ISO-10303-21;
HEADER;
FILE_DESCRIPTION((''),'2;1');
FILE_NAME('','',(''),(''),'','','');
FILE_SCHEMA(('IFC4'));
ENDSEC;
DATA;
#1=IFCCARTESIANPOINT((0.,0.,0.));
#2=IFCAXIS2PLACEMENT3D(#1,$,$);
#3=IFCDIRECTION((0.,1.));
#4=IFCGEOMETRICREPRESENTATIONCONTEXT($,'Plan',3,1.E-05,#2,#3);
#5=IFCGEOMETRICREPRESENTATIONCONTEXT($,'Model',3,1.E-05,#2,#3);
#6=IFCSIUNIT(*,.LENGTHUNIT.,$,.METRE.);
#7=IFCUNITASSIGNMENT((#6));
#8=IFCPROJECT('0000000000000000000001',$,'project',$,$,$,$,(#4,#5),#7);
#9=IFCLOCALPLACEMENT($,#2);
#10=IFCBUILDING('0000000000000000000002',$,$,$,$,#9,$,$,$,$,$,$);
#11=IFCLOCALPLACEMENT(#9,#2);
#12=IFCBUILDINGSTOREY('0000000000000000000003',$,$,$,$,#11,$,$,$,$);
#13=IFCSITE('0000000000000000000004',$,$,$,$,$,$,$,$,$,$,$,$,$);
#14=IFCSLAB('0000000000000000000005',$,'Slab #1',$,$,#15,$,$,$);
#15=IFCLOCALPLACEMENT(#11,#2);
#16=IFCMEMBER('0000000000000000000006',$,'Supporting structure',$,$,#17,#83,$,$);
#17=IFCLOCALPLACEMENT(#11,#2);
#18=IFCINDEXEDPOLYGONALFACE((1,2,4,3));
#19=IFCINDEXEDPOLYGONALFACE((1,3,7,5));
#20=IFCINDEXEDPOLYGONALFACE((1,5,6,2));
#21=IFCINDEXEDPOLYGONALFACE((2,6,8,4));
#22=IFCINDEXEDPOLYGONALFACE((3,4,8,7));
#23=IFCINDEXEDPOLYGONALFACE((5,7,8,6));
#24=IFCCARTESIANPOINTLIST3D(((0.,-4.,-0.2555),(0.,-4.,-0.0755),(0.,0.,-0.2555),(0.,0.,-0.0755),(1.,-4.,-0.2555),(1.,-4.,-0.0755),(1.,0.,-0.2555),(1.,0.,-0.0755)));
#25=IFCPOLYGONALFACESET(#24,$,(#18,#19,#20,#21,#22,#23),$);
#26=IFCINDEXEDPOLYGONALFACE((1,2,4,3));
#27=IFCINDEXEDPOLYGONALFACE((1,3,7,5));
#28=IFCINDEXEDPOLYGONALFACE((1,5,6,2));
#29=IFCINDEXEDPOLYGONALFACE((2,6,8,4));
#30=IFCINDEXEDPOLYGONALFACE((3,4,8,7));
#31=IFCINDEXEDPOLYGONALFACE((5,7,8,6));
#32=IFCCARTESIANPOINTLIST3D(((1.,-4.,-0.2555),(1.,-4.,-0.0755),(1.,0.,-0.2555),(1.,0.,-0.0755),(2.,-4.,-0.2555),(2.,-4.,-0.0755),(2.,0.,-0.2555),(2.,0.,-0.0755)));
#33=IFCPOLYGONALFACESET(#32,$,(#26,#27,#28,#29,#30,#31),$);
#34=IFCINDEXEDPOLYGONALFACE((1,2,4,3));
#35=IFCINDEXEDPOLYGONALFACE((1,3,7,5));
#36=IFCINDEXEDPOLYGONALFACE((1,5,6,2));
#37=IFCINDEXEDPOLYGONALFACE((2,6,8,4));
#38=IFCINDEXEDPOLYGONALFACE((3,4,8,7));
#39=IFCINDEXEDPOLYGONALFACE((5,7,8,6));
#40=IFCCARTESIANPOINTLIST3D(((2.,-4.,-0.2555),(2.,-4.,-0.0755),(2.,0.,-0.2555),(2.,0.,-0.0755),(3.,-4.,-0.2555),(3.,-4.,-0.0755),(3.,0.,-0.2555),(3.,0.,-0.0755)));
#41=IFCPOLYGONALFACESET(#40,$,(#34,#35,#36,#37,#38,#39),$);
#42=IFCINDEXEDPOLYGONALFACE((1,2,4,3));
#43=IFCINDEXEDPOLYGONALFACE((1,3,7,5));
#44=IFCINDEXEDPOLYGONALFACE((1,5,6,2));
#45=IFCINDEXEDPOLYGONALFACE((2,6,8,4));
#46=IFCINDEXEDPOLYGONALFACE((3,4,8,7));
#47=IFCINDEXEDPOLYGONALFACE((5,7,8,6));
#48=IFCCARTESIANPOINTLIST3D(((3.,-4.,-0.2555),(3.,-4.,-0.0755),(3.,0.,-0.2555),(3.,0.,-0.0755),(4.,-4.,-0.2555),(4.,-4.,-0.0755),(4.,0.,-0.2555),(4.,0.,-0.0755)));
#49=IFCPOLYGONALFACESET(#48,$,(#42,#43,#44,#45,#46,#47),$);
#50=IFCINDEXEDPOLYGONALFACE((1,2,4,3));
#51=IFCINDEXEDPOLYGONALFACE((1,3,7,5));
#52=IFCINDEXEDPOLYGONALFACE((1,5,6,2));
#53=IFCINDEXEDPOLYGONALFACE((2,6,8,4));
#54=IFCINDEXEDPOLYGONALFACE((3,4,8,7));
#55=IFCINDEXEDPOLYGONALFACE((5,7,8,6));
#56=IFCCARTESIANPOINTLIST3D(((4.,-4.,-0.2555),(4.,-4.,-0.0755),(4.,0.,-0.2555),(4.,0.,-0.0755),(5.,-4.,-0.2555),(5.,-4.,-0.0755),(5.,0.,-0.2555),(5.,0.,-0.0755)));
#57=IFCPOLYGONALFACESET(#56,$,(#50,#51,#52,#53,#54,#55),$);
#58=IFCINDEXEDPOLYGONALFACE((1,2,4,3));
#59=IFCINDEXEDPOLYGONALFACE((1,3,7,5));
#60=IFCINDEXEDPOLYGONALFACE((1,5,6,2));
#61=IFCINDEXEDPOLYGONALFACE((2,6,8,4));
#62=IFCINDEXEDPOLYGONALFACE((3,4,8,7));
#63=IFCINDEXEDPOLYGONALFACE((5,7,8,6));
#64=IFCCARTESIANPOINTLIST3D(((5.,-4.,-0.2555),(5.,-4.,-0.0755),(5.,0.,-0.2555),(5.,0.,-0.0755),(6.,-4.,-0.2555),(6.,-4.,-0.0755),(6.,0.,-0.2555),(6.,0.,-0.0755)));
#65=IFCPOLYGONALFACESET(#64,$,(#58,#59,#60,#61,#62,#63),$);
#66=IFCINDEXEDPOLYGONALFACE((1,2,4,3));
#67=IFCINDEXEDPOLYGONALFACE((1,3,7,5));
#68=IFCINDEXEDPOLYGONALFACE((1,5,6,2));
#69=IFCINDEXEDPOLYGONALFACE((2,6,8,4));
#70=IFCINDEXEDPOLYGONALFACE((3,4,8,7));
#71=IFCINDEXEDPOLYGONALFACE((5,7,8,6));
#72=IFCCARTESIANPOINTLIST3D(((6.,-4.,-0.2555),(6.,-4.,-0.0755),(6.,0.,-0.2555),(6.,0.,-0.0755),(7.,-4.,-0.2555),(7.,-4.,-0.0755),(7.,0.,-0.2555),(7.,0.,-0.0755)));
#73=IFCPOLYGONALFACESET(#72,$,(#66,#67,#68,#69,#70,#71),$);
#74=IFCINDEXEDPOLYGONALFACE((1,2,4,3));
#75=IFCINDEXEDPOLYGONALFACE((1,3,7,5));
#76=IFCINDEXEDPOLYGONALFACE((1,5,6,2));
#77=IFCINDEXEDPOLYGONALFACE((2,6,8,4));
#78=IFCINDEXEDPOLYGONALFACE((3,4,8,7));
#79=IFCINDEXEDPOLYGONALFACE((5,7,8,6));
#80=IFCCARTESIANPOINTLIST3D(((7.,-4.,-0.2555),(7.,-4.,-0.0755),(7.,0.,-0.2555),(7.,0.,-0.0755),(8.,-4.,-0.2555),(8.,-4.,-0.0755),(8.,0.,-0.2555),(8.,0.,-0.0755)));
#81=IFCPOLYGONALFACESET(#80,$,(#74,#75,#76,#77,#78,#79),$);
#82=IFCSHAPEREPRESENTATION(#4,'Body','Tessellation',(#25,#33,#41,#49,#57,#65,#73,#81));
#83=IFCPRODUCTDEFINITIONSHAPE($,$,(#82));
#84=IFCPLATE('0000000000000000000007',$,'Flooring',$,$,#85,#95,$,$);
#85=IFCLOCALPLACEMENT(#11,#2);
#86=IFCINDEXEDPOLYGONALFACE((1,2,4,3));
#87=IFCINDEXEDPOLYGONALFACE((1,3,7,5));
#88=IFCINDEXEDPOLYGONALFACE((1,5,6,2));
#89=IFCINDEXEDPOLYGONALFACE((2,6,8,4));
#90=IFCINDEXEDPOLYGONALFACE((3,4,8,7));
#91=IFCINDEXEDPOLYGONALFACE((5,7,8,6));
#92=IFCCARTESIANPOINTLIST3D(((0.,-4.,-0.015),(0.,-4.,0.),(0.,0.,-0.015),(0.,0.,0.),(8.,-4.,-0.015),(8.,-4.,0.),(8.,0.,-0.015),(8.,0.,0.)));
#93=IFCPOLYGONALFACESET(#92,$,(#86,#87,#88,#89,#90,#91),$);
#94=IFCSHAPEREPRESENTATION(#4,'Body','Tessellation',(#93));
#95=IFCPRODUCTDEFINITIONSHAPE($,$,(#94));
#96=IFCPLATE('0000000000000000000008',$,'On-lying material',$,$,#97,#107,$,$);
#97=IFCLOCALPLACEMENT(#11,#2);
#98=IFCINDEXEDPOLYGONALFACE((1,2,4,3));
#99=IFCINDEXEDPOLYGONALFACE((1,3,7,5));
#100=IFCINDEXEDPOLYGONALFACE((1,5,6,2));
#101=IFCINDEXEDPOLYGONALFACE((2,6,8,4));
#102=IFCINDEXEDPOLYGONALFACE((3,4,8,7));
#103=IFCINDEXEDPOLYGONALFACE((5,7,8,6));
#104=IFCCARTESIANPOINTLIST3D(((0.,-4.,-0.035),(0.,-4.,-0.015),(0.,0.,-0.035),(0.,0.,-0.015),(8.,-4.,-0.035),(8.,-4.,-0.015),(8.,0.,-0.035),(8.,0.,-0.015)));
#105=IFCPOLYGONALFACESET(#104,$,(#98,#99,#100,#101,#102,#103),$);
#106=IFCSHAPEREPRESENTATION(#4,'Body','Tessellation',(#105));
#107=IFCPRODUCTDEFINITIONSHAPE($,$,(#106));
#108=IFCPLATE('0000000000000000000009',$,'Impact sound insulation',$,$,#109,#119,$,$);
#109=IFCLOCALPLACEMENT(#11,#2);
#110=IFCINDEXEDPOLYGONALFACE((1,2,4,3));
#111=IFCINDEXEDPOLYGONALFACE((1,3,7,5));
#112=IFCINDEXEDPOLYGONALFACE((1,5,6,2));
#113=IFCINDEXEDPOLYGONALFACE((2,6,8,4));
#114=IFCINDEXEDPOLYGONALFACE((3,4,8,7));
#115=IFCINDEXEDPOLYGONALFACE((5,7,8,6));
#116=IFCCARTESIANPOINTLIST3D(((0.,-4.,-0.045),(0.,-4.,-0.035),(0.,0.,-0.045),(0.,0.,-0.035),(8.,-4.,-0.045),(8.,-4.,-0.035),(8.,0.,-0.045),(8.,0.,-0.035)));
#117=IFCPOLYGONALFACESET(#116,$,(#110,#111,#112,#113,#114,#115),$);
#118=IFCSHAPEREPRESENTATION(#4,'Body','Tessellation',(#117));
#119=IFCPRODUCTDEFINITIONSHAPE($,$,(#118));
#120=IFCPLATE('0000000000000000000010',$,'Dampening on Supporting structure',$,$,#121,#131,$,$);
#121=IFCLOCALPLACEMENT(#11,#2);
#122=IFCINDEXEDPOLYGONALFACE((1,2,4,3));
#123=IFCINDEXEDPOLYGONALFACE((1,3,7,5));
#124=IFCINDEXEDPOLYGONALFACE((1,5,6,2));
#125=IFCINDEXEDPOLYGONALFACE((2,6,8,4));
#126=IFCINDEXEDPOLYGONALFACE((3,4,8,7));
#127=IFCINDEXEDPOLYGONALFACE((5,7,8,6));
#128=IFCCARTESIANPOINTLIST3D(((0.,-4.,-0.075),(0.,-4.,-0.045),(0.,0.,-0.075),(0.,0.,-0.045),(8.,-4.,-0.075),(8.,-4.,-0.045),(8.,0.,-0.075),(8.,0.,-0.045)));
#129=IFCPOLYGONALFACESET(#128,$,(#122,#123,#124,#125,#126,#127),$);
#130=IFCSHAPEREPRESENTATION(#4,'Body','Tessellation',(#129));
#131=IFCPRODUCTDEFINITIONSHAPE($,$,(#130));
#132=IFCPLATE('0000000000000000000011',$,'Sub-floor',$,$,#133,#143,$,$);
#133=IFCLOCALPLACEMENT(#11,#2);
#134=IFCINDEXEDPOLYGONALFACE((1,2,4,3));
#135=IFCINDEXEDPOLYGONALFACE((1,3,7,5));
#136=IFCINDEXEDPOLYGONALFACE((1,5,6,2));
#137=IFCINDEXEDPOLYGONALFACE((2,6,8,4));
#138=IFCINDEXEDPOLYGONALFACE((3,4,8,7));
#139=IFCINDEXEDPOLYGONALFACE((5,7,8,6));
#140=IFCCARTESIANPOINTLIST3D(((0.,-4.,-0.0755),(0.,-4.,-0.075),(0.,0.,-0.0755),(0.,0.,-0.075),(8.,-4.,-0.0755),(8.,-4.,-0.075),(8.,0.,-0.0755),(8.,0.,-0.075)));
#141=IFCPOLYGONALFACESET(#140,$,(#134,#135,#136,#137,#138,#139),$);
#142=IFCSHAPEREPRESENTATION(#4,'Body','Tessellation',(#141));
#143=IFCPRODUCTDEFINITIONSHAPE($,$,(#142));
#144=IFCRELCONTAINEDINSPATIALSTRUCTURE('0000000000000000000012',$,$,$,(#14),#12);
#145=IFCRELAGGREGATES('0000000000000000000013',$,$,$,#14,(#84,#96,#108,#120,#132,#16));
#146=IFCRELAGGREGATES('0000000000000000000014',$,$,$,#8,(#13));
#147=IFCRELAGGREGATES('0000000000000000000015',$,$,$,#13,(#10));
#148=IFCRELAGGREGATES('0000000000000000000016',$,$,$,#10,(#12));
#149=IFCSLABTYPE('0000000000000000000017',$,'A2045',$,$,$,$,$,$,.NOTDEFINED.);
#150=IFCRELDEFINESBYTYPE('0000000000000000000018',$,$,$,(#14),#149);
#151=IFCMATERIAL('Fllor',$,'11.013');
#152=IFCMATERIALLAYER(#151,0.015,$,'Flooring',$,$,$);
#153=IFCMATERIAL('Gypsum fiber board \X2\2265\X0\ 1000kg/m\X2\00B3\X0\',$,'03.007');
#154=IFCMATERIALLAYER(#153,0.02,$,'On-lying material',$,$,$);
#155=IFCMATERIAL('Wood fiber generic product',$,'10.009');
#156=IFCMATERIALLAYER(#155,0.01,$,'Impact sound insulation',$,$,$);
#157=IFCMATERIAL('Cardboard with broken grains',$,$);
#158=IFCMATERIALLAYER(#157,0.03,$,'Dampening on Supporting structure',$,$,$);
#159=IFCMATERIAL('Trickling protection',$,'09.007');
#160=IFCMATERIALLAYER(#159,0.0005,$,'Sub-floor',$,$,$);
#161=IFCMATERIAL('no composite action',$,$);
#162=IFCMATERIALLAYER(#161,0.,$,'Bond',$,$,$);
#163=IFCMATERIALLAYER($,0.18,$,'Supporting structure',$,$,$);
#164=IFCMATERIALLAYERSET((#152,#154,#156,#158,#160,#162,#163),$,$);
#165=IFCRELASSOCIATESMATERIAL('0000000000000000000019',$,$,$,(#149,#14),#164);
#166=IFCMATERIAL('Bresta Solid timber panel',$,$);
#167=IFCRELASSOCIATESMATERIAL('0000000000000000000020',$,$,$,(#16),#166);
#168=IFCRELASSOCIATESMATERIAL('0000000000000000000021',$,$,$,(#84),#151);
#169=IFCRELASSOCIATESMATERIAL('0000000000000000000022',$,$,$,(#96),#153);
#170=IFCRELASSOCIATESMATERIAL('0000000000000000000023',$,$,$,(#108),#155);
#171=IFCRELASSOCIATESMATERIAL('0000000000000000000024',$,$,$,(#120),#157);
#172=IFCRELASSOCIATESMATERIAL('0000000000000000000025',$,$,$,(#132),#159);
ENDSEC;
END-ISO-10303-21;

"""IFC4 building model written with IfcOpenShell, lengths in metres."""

from ifc_helpers import new_model, si_unit, direction, frame, frame_2d, origin, origin_with_axes, place, context, project, spatial, rectangle, extrude, material, layer, layer_set, type_object, element, aggregate, save


model = new_model("IFC4")

# Units and contexts
plan_context = context("Plan", 3, precision=1e-05, world=origin(), true_north=direction((0.0, 1.0)))
model_context = context("Model", 3, precision=1e-05, world=origin(), true_north=direction((0.0, 1.0)))
ifc_project = project(units=[si_unit("LENGTHUNIT", "METRE")], contexts=[plan_context, model_context])

# Site, building, storey
site = spatial("IfcSite", under=ifc_project)
building_placement = place(None, origin())
building = spatial("IfcBuilding", under=site, at=building_placement)
storey_placement = place(building_placement, origin())
storey = spatial("IfcBuildingStorey", under=building, at=storey_placement)

# Slab, member, plates
ifc_material_1 = material(Name="Fllor", Category="11.013")
ifc_layer_1 = layer(ifc_material_1, 0.015, Name="Flooring")
ifc_material_2 = material(Name="Gypsum fiber board ≥ 1000kg/m³", Category="03.007")
ifc_layer_2 = layer(ifc_material_2, 0.02, Name="On-lying material")
ifc_material_3 = material(Name="Wood fiber generic product", Category="10.009")
ifc_layer_3 = layer(ifc_material_3, 0.01, Name="Impact sound insulation")
ifc_material_4 = material(Name="Cardboard with broken grains")
ifc_layer_4 = layer(ifc_material_4, 0.03, Name="Dampening on Supporting structure")
ifc_material_5 = material(Name="Trickling protection", Category="09.007")
ifc_layer_5 = layer(ifc_material_5, 0.0005, Name="Sub-floor")
ifc_material_6 = material(Name="no composite action")
ifc_layer_6 = layer(ifc_material_6, 0.0, Name="Bond")
ifc_layer_7 = layer(None, 0.18, Name="Supporting structure")
ifc_layer_set = layer_set([ifc_layer_1, ifc_layer_2, ifc_layer_3, ifc_layer_4, ifc_layer_5, ifc_layer_6, ifc_layer_7])
slab_type = type_object("IfcSlabType", Name="A2045", PredefinedType="NOTDEFINED", material=ifc_layer_set)
slab_placement = place(None, frame((0.0, 0.0, 0.0), z_axis=(0.0, 0.0, -1.0), x_axis=(1.0, 0.0, 0.0)))
slab = element("IfcSlab", 1, at=slab_placement, inside=storey, type_object=slab_type, material=ifc_layer_set, Name="Slab #1")
ifc_material_7 = material(Name="Bresta Solid timber panel")
member_placement = place(slab_placement, origin())
member = element("IfcMember", 2, at=member_placement, material=ifc_material_7, Name="Supporting structure", context=plan_context, shape_type="SweptSolid", body=[
    extrude(rectangle(XDim=1.0, YDim=0.18, at=frame_2d((0.5, 0.09), x_axis=(1.0, 0.0))), frame((0.0, 4.0, 0.0755), z_axis=(0.0, -1.0, 0.0), x_axis=(1.0, 0.0, 0.0)), (0.0, 0.0, 1.0), 4.0),
    extrude(rectangle(XDim=1.0, YDim=0.18, at=frame_2d((0.5, 0.09), x_axis=(1.0, 0.0))), frame((1.0, 4.0, 0.0755), z_axis=(0.0, -1.0, 0.0), x_axis=(1.0, 0.0, 0.0)), (0.0, 0.0, 1.0), 4.0),
    extrude(rectangle(XDim=1.0, YDim=0.18, at=frame_2d((0.5, 0.09), x_axis=(1.0, 0.0))), frame((2.0, 4.0, 0.0755), z_axis=(0.0, -1.0, 0.0), x_axis=(1.0, 0.0, 0.0)), (0.0, 0.0, 1.0), 4.0),
    extrude(rectangle(XDim=1.0, YDim=0.18, at=frame_2d((0.5, 0.09), x_axis=(1.0, 0.0))), frame((3.0, 4.0, 0.0755), z_axis=(0.0, -1.0, 0.0), x_axis=(1.0, 0.0, 0.0)), (0.0, 0.0, 1.0), 4.0),
    extrude(rectangle(XDim=1.0, YDim=0.18, at=frame_2d((0.5, 0.09), x_axis=(1.0, 0.0))), frame((4.0, 4.0, 0.0755), z_axis=(0.0, -1.0, 0.0), x_axis=(1.0, 0.0, 0.0)), (0.0, 0.0, 1.0), 4.0),
    extrude(rectangle(XDim=1.0, YDim=0.18, at=frame_2d((0.5, 0.09), x_axis=(1.0, 0.0))), frame((5.0, 4.0, 0.0755), z_axis=(0.0, -1.0, 0.0), x_axis=(1.0, 0.0, 0.0)), (0.0, 0.0, 1.0), 4.0),
    extrude(rectangle(XDim=1.0, YDim=0.18, at=frame_2d((0.5, 0.09), x_axis=(1.0, 0.0))), frame((6.0, 4.0, 0.0755), z_axis=(0.0, -1.0, 0.0), x_axis=(1.0, 0.0, 0.0)), (0.0, 0.0, 1.0), 4.0),
    extrude(rectangle(XDim=1.0, YDim=0.18, at=frame_2d((0.5, 0.09), x_axis=(1.0, 0.0))), frame((7.0, 4.0, 0.0755), z_axis=(0.0, -1.0, 0.0), x_axis=(1.0, 0.0, 0.0)), (0.0, 0.0, 1.0), 4.0),
])
plate_1_placement = place(slab_placement, origin())
plate_1 = element("IfcPlate", 3, at=plate_1_placement, material=ifc_material_1, Name="Flooring", context=plan_context, shape_type="SweptSolid", body=[
    extrude(rectangle(XDim=8.0, YDim=4.0, at=frame_2d((4.0, 2.0), x_axis=(1.0, 0.0))), origin_with_axes(), (0.0, 0.0, 1.0), 0.015),
])
plate_2_placement = place(slab_placement, origin())
plate_2 = element("IfcPlate", 4, at=plate_2_placement, material=ifc_material_2, Name="On-lying material", context=plan_context, shape_type="SweptSolid", body=[
    extrude(rectangle(XDim=8.0, YDim=4.0, at=frame_2d((4.0, 2.0), x_axis=(1.0, 0.0))), frame((0.0, 0.0, 0.015), z_axis=(0.0, 0.0, 1.0), x_axis=(1.0, 0.0, 0.0)), (0.0, 0.0, 1.0), 0.02),
])
plate_3_placement = place(slab_placement, origin())
plate_3 = element("IfcPlate", 5, at=plate_3_placement, material=ifc_material_3, Name="Impact sound insulation", context=plan_context, shape_type="SweptSolid", body=[
    extrude(rectangle(XDim=8.0, YDim=4.0, at=frame_2d((4.0, 2.0), x_axis=(1.0, 0.0))), frame((0.0, 0.0, 0.035), z_axis=(0.0, 0.0, 1.0), x_axis=(1.0, 0.0, 0.0)), (0.0, 0.0, 1.0), 0.01),
])
plate_4_placement = place(slab_placement, origin())
plate_4 = element("IfcPlate", 6, at=plate_4_placement, material=ifc_material_4, Name="Dampening on Supporting structure", context=plan_context, shape_type="SweptSolid", body=[
    extrude(rectangle(XDim=8.0, YDim=4.0, at=frame_2d((4.0, 2.0), x_axis=(1.0, 0.0))), frame((0.0, 0.0, 0.045), z_axis=(0.0, 0.0, 1.0), x_axis=(1.0, 0.0, 0.0)), (0.0, 0.0, 1.0), 0.03),
])
plate_5_placement = place(slab_placement, origin())
plate_5 = element("IfcPlate", 7, at=plate_5_placement, material=ifc_material_5, Name="Sub-floor", context=plan_context, shape_type="SweptSolid", body=[
    extrude(rectangle(XDim=8.0, YDim=4.0, at=frame_2d((4.0, 2.0), x_axis=(1.0, 0.0))), frame((0.0, 0.0, 0.075), z_axis=(0.0, 0.0, 1.0), x_axis=(1.0, 0.0, 0.0)), (0.0, 0.0, 1.0), 0.0005),
])
aggregate(slab, [plate_1, plate_2, plate_3, plate_4, plate_5, member])

save(model, "model.ifc")
